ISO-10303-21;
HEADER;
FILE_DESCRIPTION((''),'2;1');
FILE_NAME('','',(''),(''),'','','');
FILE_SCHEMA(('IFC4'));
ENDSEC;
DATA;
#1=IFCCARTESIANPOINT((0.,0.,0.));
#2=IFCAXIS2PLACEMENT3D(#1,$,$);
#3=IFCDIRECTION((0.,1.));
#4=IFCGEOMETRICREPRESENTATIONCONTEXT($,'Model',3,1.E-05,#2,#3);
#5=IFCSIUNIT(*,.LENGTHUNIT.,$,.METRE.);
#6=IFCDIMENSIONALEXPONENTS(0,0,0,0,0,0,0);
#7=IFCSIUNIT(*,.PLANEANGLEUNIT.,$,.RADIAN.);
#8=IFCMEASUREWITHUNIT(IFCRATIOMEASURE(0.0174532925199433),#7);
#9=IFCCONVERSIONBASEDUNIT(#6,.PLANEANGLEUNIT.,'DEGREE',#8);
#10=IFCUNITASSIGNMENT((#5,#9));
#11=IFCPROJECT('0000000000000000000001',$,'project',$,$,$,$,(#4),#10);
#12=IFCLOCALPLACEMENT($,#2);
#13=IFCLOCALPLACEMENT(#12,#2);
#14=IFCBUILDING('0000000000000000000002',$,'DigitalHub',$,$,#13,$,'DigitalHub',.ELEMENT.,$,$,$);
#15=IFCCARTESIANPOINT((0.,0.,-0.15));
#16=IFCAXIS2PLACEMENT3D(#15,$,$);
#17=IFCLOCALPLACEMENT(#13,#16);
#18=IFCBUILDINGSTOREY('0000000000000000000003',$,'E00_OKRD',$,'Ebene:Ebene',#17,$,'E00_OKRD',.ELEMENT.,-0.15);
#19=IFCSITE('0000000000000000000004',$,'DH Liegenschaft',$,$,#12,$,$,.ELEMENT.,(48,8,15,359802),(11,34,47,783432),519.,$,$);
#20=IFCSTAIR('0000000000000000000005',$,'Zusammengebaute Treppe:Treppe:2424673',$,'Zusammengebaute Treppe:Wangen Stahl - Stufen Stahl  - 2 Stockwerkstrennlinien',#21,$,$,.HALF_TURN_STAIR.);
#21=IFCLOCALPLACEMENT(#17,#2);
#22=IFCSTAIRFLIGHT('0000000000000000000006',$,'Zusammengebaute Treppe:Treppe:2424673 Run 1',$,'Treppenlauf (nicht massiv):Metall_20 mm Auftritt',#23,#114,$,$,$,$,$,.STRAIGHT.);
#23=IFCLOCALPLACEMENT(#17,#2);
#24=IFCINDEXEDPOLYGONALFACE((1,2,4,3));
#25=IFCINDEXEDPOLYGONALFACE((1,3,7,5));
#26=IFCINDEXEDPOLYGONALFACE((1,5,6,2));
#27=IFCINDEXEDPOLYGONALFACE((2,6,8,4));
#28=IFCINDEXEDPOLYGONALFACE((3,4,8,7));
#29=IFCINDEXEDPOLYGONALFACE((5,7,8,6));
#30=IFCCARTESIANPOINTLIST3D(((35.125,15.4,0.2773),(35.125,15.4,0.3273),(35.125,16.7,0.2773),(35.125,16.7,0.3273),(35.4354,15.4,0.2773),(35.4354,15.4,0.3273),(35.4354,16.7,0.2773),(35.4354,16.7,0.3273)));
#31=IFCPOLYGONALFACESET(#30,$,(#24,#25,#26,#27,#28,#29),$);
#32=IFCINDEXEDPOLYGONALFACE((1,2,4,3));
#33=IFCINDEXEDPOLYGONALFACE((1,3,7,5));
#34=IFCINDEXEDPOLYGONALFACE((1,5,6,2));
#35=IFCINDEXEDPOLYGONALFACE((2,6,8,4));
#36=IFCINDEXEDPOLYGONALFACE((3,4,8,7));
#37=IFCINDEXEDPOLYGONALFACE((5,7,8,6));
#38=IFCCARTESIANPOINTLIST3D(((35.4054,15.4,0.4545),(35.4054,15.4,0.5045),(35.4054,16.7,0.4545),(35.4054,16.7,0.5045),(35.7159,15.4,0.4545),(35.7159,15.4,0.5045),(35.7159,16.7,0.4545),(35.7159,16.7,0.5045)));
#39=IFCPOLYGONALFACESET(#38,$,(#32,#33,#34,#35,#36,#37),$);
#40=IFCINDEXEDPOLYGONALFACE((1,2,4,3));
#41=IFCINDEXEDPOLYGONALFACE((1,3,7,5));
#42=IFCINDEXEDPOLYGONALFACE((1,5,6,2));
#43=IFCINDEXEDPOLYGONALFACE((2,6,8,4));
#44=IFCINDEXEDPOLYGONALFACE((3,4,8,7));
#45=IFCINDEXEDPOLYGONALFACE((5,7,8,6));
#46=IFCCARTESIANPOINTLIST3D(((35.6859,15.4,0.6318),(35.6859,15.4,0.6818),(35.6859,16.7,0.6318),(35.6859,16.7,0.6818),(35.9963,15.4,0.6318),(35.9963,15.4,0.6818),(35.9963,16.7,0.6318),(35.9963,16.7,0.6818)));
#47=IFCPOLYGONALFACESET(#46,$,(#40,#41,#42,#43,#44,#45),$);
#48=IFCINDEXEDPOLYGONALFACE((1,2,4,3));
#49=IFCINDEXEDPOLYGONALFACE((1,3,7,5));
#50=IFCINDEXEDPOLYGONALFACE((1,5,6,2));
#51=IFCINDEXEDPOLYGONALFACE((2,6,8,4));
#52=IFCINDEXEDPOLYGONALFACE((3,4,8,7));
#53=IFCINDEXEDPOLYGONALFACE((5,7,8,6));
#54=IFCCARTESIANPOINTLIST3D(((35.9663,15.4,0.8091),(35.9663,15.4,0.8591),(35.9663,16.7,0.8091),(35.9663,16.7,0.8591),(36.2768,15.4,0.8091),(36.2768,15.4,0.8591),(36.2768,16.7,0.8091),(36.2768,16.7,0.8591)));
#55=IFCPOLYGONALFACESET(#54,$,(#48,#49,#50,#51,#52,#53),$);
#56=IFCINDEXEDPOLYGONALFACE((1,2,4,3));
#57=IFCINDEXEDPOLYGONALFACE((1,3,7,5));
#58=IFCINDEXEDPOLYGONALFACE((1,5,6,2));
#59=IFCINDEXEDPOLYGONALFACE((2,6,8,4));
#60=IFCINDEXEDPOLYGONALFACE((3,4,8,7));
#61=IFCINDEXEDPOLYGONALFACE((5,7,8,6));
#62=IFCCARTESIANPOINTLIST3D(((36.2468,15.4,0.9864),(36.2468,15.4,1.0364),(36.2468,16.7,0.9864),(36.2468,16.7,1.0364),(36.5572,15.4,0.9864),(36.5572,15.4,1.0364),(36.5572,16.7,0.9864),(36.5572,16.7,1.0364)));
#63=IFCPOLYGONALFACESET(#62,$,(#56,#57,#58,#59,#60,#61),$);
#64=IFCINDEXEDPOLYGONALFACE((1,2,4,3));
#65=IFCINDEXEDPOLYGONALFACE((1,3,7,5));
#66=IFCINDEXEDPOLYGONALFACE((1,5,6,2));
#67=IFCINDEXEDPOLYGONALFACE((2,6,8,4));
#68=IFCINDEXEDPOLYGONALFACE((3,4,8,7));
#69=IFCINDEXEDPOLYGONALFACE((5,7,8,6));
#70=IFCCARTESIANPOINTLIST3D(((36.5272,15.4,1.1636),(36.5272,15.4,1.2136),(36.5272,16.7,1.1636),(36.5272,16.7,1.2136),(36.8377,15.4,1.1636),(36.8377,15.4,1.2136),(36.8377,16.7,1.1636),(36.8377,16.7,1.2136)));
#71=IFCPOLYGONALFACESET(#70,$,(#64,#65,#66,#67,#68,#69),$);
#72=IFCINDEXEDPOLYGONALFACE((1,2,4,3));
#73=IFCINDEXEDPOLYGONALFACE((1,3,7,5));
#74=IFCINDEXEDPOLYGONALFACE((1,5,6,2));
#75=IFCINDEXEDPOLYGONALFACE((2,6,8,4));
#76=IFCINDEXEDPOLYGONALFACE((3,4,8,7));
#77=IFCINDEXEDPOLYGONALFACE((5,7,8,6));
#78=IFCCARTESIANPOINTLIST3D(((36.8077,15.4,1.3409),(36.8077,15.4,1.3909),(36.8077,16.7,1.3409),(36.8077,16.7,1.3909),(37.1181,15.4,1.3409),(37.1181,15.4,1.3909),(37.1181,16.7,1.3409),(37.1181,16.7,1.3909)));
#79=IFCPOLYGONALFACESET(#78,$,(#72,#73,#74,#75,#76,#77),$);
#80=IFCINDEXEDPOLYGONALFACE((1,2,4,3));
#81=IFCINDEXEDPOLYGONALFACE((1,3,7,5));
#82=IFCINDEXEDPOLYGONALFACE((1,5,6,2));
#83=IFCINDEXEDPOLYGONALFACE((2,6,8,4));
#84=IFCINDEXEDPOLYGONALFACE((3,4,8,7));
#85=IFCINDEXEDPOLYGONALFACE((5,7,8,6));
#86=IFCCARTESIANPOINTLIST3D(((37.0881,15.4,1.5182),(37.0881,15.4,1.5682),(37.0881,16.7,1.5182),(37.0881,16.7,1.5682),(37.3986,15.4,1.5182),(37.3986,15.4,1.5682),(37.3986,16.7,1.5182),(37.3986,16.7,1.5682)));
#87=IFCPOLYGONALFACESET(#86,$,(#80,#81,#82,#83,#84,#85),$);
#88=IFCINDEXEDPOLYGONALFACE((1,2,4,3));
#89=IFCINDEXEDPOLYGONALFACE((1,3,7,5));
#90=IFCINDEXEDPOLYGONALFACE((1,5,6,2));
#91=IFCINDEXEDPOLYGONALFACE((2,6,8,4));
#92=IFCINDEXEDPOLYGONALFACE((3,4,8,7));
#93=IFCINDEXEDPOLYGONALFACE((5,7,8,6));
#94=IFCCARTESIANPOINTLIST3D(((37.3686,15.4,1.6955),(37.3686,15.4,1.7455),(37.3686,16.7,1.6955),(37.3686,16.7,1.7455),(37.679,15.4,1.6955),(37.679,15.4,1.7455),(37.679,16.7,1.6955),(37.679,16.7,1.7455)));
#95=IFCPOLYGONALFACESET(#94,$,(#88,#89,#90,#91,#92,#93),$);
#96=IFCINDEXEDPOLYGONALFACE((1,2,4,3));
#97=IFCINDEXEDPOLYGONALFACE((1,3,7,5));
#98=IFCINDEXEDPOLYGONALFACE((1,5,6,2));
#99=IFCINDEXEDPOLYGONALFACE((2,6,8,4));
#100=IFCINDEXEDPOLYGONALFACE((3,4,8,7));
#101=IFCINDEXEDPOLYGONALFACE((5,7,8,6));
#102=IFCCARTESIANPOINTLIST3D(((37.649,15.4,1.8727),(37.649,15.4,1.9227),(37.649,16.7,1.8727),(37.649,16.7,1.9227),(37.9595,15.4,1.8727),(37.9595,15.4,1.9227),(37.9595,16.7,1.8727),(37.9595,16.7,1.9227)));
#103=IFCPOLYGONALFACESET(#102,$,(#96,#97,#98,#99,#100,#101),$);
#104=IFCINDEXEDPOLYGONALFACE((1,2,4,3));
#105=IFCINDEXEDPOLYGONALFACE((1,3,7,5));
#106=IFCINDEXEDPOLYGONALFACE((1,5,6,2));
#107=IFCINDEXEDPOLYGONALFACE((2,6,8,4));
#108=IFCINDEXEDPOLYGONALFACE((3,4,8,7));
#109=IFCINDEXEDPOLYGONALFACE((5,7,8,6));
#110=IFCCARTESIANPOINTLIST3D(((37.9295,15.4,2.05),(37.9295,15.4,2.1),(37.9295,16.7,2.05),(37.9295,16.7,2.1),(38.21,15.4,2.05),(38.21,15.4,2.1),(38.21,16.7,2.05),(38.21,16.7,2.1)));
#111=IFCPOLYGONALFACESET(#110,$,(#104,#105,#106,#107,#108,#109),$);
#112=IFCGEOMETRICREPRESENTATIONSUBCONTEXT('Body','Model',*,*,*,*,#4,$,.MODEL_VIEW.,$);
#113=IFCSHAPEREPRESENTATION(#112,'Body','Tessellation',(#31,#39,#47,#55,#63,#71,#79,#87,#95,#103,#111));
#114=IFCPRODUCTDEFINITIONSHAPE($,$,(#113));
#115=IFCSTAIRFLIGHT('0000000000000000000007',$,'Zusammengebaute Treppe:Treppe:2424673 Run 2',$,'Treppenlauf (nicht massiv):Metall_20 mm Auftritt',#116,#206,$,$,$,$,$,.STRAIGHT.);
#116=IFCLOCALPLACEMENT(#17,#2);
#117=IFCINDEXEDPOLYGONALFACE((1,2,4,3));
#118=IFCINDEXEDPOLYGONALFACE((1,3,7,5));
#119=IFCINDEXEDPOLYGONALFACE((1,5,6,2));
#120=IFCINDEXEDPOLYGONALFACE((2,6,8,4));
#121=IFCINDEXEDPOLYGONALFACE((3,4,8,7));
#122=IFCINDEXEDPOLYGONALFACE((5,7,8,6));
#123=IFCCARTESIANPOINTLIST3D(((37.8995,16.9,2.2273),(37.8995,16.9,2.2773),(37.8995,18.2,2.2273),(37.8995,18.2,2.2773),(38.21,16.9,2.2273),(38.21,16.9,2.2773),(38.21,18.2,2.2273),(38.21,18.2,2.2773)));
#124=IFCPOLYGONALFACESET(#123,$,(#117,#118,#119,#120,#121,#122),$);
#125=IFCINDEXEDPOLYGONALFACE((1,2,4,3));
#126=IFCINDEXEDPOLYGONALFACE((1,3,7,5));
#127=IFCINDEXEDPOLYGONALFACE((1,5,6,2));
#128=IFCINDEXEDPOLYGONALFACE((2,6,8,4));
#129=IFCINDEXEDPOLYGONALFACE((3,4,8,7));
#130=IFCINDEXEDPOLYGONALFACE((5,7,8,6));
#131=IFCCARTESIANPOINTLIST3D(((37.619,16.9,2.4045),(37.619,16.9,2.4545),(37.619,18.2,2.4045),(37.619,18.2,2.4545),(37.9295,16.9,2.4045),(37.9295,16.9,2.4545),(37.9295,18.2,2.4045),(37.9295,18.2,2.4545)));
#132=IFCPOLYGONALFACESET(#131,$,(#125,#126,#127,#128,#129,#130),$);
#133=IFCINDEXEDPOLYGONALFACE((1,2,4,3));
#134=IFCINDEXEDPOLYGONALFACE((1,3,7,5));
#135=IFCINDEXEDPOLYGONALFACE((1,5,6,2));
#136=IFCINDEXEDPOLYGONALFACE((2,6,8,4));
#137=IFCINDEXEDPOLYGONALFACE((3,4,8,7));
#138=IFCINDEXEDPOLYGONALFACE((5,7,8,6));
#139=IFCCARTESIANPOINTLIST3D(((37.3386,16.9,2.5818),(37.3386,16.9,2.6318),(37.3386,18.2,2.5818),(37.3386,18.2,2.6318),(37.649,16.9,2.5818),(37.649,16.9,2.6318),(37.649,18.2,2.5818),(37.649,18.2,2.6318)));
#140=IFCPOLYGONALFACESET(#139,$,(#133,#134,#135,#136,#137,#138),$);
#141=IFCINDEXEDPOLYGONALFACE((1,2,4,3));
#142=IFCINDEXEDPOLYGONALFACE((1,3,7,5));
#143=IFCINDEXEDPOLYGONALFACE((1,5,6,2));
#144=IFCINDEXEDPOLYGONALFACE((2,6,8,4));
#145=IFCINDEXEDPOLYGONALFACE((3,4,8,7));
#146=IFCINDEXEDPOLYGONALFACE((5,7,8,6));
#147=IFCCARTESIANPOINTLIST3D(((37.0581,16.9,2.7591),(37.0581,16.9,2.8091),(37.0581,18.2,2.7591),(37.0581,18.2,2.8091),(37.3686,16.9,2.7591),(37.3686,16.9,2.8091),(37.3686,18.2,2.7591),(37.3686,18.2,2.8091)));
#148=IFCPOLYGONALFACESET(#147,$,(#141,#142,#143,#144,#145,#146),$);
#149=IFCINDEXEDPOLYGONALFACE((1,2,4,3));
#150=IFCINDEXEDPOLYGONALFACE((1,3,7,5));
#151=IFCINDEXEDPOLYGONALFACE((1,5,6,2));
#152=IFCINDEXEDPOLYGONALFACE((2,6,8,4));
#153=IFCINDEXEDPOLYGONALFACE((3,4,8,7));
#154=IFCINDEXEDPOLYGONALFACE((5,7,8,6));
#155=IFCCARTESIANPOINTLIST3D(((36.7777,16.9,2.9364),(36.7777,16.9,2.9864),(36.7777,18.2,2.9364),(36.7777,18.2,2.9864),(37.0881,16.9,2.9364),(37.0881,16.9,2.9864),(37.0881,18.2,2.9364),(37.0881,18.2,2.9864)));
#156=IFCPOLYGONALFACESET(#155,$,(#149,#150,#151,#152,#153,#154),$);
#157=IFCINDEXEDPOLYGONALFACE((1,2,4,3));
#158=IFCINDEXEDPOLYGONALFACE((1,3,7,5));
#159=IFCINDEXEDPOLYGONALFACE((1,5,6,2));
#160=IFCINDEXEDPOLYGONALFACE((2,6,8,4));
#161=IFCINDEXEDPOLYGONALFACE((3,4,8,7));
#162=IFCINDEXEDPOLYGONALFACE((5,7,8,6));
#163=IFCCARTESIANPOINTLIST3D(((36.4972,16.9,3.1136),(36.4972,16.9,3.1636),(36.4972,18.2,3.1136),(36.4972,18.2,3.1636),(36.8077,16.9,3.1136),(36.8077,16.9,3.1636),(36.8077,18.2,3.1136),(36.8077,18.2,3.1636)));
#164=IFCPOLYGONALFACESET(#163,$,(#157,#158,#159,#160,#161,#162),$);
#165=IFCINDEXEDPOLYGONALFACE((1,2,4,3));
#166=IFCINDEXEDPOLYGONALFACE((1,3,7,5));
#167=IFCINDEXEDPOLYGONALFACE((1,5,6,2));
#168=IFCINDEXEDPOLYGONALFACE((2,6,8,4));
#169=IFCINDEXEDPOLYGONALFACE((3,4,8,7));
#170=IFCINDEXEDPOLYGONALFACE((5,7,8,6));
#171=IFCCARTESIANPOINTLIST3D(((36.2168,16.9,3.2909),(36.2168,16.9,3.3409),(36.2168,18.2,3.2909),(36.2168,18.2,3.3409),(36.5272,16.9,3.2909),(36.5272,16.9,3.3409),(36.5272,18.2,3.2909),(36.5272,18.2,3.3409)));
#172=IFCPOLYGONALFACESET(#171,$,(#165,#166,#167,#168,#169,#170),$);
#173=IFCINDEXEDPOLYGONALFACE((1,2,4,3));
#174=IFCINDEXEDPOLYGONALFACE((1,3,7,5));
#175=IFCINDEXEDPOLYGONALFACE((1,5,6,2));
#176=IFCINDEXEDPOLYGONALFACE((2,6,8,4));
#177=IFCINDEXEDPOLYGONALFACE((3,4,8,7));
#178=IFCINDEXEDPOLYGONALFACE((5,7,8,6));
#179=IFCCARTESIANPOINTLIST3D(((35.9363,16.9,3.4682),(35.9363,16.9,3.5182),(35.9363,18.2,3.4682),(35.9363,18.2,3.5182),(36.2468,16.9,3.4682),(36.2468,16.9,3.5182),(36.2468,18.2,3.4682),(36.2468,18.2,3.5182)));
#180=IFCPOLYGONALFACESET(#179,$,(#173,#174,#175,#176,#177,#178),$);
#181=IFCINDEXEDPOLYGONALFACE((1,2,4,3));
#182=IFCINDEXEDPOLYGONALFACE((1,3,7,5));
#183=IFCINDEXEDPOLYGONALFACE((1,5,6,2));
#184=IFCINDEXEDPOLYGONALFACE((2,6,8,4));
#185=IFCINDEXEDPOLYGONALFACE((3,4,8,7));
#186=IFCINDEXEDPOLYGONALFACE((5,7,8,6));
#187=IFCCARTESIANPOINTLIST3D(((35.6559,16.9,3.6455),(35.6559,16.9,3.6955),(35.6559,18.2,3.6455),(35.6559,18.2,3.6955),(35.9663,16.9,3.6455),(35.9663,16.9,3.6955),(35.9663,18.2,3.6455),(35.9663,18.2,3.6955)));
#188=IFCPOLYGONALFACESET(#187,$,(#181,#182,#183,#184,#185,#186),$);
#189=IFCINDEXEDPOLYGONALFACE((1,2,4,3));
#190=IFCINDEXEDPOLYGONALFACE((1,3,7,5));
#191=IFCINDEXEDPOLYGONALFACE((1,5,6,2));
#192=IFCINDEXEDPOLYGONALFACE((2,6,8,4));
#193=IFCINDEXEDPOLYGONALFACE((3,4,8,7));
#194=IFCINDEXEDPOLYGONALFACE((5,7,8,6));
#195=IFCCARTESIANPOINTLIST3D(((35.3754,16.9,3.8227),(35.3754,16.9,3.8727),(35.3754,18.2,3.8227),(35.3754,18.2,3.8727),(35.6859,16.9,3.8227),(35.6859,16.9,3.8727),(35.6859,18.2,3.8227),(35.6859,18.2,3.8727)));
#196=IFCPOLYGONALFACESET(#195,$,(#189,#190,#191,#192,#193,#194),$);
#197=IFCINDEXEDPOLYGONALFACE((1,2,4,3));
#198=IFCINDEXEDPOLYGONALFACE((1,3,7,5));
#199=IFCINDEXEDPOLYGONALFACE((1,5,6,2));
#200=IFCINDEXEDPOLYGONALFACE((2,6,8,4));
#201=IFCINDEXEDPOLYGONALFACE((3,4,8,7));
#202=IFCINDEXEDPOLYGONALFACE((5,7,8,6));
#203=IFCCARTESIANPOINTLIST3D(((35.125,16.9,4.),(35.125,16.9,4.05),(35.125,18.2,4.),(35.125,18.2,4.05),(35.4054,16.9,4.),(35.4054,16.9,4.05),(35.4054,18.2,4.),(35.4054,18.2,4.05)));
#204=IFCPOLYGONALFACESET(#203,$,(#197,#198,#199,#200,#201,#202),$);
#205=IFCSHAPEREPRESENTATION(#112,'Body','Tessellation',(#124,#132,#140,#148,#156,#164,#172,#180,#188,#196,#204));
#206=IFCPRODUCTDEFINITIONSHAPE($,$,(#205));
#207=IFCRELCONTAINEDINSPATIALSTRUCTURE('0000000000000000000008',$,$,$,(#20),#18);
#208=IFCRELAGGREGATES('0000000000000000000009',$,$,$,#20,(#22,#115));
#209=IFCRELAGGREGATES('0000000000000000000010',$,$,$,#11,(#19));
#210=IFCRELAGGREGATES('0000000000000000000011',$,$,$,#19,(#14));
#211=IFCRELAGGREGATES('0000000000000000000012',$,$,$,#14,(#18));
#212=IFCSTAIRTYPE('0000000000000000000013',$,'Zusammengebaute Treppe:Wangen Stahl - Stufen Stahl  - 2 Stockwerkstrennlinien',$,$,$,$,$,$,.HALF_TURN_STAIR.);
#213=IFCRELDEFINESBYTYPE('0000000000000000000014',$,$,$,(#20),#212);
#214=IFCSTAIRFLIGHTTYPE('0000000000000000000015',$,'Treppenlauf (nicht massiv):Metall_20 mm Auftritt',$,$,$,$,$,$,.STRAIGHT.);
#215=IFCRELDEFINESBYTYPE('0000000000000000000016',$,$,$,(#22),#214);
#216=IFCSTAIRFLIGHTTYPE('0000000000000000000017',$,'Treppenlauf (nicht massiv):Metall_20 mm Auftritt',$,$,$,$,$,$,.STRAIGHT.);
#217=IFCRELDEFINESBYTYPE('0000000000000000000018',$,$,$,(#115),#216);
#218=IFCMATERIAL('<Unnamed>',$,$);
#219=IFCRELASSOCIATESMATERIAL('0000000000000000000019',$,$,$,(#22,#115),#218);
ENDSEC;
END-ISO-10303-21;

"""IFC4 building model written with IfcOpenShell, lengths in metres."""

from ifc_helpers import new_model, entity, si_unit, converted_unit, direction, frame, origin, place, context, subcontext, project, spatial, indexed_curve, outline, extrude, material, type_object, element, aggregate, save


model = new_model("IFC4")

# Units and contexts
model_context = context("Model", 3, precision=1e-05, world=origin(), true_north=direction((0.0, 1.0)))
body_context = subcontext(model_context, "Body", "Model", "MODEL_VIEW")
ifc_project = project(units=[si_unit("LENGTHUNIT", "METRE"), converted_unit("PLANEANGLEUNIT", "DEGREE", entity("IfcRatioMeasure", 0.0174532925199433), si_unit("PLANEANGLEUNIT", "RADIAN"), dimensions=[0, 0, 0, 0, 0, 0, 0])], contexts=[model_context])

# Site, building, storey
site_placement = place(None, frame((0.0, 0.0, 0.0)))
site = spatial("IfcSite", under=ifc_project, at=site_placement, Name="DH Liegenschaft", CompositionType="ELEMENT", RefLatitude=(48, 8, 15, 359802), RefLongitude=(11, 34, 47, 783432), RefElevation=519.0)
building_placement = place(site_placement, origin())
building = spatial("IfcBuilding", under=site, at=building_placement, Name="DigitalHub", LongName="DigitalHub", CompositionType="ELEMENT")
storey_placement = place(building_placement, frame((0.0, 0.0, -0.15)))
storey = spatial("IfcBuildingStorey", under=building, at=storey_placement, Name="E00_OKRD", ObjectType="Ebene:Ebene", LongName="E00_OKRD", CompositionType="ELEMENT", Elevation=-0.15)

# Stair
stair_type = type_object("IfcStairType", Name="Zusammengebaute Treppe:Wangen Stahl - Stufen Stahl  - 2 Stockwerkstrennlinien", PredefinedType="HALF_TURN_STAIR")
stair_placement = place(storey_placement, origin())
stair = element("IfcStair", 1, at=stair_placement, inside=storey, type_object=stair_type, Name="Zusammengebaute Treppe:Treppe:2424673", ObjectType="Zusammengebaute Treppe:Wangen Stahl - Stufen Stahl  - 2 Stockwerkstrennlinien", PredefinedType="HALF_TURN_STAIR")
ifc_material_1 = material(Name="<Unnamed>")

# Stair flights
stair_flight_type_1 = type_object("IfcStairFlightType", Name="Treppenlauf (nicht massiv):Metall_20 mm Auftritt", PredefinedType="STRAIGHT")
stair_flight_1_placement = place(stair_placement, frame((35.125, 15.4, 0.0)))
stair_flight_1 = element("IfcStairFlight", 2, at=stair_flight_1_placement, type_object=stair_flight_type_1, material=ifc_material_1, Name="Zusammengebaute Treppe:Treppe:2424673 Run 1", ObjectType="Treppenlauf (nicht massiv):Metall_20 mm Auftritt", PredefinedType="STRAIGHT", context=body_context, shape_type="SweptSolid", body=[
    extrude(outline(indexed_curve([(-0.1552, -0.65), (0.1552, -0.65), (0.1552, 0.65), (-0.1552, 0.65), (-0.1552, -0.65)], self_intersect=False)), frame((0.1552, 0.65, 0.2773), z_axis=(0.0, 0.0, 1.0), x_axis=(-1.0, 0.0, 0.0)), (0.0, 0.0, 1.0), 0.05),
    extrude(outline(indexed_curve([(-0.1552, -0.65), (0.1552, -0.65), (0.1552, 0.65), (-0.1552, 0.65), (-0.1552, -0.65)], self_intersect=False)), frame((0.4357, 0.65, 0.4545), z_axis=(0.0, 0.0, 1.0), x_axis=(-1.0, 0.0, 0.0)), (0.0, 0.0, 1.0), 0.05),
    extrude(outline(indexed_curve([(-0.1552, -0.65), (0.1552, -0.65), (0.1552, 0.65), (-0.1552, 0.65), (-0.1552, -0.65)], self_intersect=False)), frame((0.7161, 0.65, 0.6318), z_axis=(0.0, 0.0, 1.0), x_axis=(-1.0, 0.0, 0.0)), (0.0, 0.0, 1.0), 0.05),
    extrude(outline(indexed_curve([(-0.1552, -0.65), (0.1552, -0.65), (0.1552, 0.65), (-0.1552, 0.65), (-0.1552, -0.65)], self_intersect=False)), frame((0.9966, 0.65, 0.8091), z_axis=(0.0, 0.0, 1.0), x_axis=(-1.0, 0.0, 0.0)), (0.0, 0.0, 1.0), 0.05),
    extrude(outline(indexed_curve([(-0.1552, -0.65), (0.1552, -0.65), (0.1552, 0.65), (-0.1552, 0.65), (-0.1552, -0.65)], self_intersect=False)), frame((1.277, 0.65, 0.9864), z_axis=(0.0, 0.0, 1.0), x_axis=(-1.0, 0.0, 0.0)), (0.0, 0.0, 1.0), 0.05),
    extrude(outline(indexed_curve([(-0.1552, -0.65), (0.1552, -0.65), (0.1552, 0.65), (-0.1552, 0.65), (-0.1552, -0.65)], self_intersect=False)), frame((1.5575, 0.65, 1.1636), z_axis=(0.0, 0.0, 1.0), x_axis=(-1.0, 0.0, 0.0)), (0.0, 0.0, 1.0), 0.05),
    extrude(outline(indexed_curve([(-0.1552, -0.65), (0.1552, -0.65), (0.1552, 0.65), (-0.1552, 0.65), (-0.1552, -0.65)], self_intersect=False)), frame((1.838, 0.65, 1.3409), z_axis=(0.0, 0.0, 1.0), x_axis=(-1.0, 0.0, 0.0)), (0.0, 0.0, 1.0), 0.05),
    extrude(outline(indexed_curve([(-0.1552, -0.65), (0.1552, -0.65), (0.1552, 0.65), (-0.1552, 0.65), (-0.1552, -0.65)], self_intersect=False)), frame((2.1184, 0.65, 1.5182), z_axis=(0.0, 0.0, 1.0), x_axis=(-1.0, 0.0, 0.0)), (0.0, 0.0, 1.0), 0.05),
    extrude(outline(indexed_curve([(-0.1552, -0.65), (0.1552, -0.65), (0.1552, 0.65), (-0.1552, 0.65), (-0.1552, -0.65)], self_intersect=False)), frame((2.3989, 0.65, 1.6955), z_axis=(0.0, 0.0, 1.0), x_axis=(-1.0, 0.0, 0.0)), (0.0, 0.0, 1.0), 0.05),
    extrude(outline(indexed_curve([(-0.1552, -0.65), (0.1552, -0.65), (0.1552, 0.65), (-0.1552, 0.65), (-0.1552, -0.65)], self_intersect=False)), frame((2.6793, 0.65, 1.8727), z_axis=(0.0, 0.0, 1.0), x_axis=(-1.0, 0.0, 0.0)), (0.0, 0.0, 1.0), 0.05),
    extrude(outline(indexed_curve([(-0.1402, -0.65), (0.1402, -0.65), (0.1402, 0.65), (-0.1402, 0.65), (-0.1402, -0.65)], self_intersect=False)), frame((2.9448, 0.65, 2.05), z_axis=(0.0, 0.0, 1.0), x_axis=(-1.0, 0.0, 0.0)), (0.0, 0.0, 1.0), 0.05),
])
stair_flight_type_2 = type_object("IfcStairFlightType", Name="Treppenlauf (nicht massiv):Metall_20 mm Auftritt", PredefinedType="STRAIGHT")
stair_flight_2_placement = place(stair_placement, frame((35.125, 16.9, 0.0)))
stair_flight_2 = element("IfcStairFlight", 3, at=stair_flight_2_placement, type_object=stair_flight_type_2, material=ifc_material_1, Name="Zusammengebaute Treppe:Treppe:2424673 Run 2", ObjectType="Treppenlauf (nicht massiv):Metall_20 mm Auftritt", PredefinedType="STRAIGHT", context=body_context, shape_type="SweptSolid", body=[
    extrude(outline(indexed_curve([(-0.1552, -0.65), (0.1552, -0.65), (0.1552, 0.65), (-0.1552, 0.65), (-0.1552, -0.65)], self_intersect=False)), frame((2.9298, 0.65, 2.2273)), (0.0, 0.0, 1.0), 0.05),
    extrude(outline(indexed_curve([(-0.1552, -0.65), (0.1552, -0.65), (0.1552, 0.65), (-0.1552, 0.65), (-0.1552, -0.65)], self_intersect=False)), frame((2.6493, 0.65, 2.4045)), (0.0, 0.0, 1.0), 0.05),
    extrude(outline(indexed_curve([(-0.1552, -0.65), (0.1552, -0.65), (0.1552, 0.65), (-0.1552, 0.65), (-0.1552, -0.65)], self_intersect=False)), frame((2.3689, 0.65, 2.5818)), (0.0, 0.0, 1.0), 0.05),
    extrude(outline(indexed_curve([(-0.1552, -0.65), (0.1552, -0.65), (0.1552, 0.65), (-0.1552, 0.65), (-0.1552, -0.65)], self_intersect=False)), frame((2.0884, 0.65, 2.7591)), (0.0, 0.0, 1.0), 0.05),
    extrude(outline(indexed_curve([(-0.1552, -0.65), (0.1552, -0.65), (0.1552, 0.65), (-0.1552, 0.65), (-0.1552, -0.65)], self_intersect=False)), frame((1.808, 0.65, 2.9364)), (0.0, 0.0, 1.0), 0.05),
    extrude(outline(indexed_curve([(-0.1552, -0.65), (0.1552, -0.65), (0.1552, 0.65), (-0.1552, 0.65), (-0.1552, -0.65)], self_intersect=False)), frame((1.5275, 0.65, 3.1136)), (0.0, 0.0, 1.0), 0.05),
    extrude(outline(indexed_curve([(-0.1552, -0.65), (0.1552, -0.65), (0.1552, 0.65), (-0.1552, 0.65), (-0.1552, -0.65)], self_intersect=False)), frame((1.247, 0.65, 3.2909)), (0.0, 0.0, 1.0), 0.05),
    extrude(outline(indexed_curve([(-0.1552, -0.65), (0.1552, -0.65), (0.1552, 0.65), (-0.1552, 0.65), (-0.1552, -0.65)], self_intersect=False)), frame((0.9666, 0.65, 3.4682)), (0.0, 0.0, 1.0), 0.05),
    extrude(outline(indexed_curve([(-0.1552, -0.65), (0.1552, -0.65), (0.1552, 0.65), (-0.1552, 0.65), (-0.1552, -0.65)], self_intersect=False)), frame((0.6861, 0.65, 3.6455)), (0.0, 0.0, 1.0), 0.05),
    extrude(outline(indexed_curve([(-0.1552, -0.65), (0.1552, -0.65), (0.1552, 0.65), (-0.1552, 0.65), (-0.1552, -0.65)], self_intersect=False)), frame((0.4057, 0.65, 3.8227)), (0.0, 0.0, 1.0), 0.05),
    extrude(outline(indexed_curve([(-0.1402, -0.65), (0.1402, -0.65), (0.1402, 0.65), (-0.1402, 0.65), (-0.1402, -0.65)], self_intersect=False)), frame((0.1402, 0.65, 4.0)), (0.0, 0.0, 1.0), 0.05),
])
aggregate(stair, [stair_flight_1, stair_flight_2])

save(model, "model.ifc")
